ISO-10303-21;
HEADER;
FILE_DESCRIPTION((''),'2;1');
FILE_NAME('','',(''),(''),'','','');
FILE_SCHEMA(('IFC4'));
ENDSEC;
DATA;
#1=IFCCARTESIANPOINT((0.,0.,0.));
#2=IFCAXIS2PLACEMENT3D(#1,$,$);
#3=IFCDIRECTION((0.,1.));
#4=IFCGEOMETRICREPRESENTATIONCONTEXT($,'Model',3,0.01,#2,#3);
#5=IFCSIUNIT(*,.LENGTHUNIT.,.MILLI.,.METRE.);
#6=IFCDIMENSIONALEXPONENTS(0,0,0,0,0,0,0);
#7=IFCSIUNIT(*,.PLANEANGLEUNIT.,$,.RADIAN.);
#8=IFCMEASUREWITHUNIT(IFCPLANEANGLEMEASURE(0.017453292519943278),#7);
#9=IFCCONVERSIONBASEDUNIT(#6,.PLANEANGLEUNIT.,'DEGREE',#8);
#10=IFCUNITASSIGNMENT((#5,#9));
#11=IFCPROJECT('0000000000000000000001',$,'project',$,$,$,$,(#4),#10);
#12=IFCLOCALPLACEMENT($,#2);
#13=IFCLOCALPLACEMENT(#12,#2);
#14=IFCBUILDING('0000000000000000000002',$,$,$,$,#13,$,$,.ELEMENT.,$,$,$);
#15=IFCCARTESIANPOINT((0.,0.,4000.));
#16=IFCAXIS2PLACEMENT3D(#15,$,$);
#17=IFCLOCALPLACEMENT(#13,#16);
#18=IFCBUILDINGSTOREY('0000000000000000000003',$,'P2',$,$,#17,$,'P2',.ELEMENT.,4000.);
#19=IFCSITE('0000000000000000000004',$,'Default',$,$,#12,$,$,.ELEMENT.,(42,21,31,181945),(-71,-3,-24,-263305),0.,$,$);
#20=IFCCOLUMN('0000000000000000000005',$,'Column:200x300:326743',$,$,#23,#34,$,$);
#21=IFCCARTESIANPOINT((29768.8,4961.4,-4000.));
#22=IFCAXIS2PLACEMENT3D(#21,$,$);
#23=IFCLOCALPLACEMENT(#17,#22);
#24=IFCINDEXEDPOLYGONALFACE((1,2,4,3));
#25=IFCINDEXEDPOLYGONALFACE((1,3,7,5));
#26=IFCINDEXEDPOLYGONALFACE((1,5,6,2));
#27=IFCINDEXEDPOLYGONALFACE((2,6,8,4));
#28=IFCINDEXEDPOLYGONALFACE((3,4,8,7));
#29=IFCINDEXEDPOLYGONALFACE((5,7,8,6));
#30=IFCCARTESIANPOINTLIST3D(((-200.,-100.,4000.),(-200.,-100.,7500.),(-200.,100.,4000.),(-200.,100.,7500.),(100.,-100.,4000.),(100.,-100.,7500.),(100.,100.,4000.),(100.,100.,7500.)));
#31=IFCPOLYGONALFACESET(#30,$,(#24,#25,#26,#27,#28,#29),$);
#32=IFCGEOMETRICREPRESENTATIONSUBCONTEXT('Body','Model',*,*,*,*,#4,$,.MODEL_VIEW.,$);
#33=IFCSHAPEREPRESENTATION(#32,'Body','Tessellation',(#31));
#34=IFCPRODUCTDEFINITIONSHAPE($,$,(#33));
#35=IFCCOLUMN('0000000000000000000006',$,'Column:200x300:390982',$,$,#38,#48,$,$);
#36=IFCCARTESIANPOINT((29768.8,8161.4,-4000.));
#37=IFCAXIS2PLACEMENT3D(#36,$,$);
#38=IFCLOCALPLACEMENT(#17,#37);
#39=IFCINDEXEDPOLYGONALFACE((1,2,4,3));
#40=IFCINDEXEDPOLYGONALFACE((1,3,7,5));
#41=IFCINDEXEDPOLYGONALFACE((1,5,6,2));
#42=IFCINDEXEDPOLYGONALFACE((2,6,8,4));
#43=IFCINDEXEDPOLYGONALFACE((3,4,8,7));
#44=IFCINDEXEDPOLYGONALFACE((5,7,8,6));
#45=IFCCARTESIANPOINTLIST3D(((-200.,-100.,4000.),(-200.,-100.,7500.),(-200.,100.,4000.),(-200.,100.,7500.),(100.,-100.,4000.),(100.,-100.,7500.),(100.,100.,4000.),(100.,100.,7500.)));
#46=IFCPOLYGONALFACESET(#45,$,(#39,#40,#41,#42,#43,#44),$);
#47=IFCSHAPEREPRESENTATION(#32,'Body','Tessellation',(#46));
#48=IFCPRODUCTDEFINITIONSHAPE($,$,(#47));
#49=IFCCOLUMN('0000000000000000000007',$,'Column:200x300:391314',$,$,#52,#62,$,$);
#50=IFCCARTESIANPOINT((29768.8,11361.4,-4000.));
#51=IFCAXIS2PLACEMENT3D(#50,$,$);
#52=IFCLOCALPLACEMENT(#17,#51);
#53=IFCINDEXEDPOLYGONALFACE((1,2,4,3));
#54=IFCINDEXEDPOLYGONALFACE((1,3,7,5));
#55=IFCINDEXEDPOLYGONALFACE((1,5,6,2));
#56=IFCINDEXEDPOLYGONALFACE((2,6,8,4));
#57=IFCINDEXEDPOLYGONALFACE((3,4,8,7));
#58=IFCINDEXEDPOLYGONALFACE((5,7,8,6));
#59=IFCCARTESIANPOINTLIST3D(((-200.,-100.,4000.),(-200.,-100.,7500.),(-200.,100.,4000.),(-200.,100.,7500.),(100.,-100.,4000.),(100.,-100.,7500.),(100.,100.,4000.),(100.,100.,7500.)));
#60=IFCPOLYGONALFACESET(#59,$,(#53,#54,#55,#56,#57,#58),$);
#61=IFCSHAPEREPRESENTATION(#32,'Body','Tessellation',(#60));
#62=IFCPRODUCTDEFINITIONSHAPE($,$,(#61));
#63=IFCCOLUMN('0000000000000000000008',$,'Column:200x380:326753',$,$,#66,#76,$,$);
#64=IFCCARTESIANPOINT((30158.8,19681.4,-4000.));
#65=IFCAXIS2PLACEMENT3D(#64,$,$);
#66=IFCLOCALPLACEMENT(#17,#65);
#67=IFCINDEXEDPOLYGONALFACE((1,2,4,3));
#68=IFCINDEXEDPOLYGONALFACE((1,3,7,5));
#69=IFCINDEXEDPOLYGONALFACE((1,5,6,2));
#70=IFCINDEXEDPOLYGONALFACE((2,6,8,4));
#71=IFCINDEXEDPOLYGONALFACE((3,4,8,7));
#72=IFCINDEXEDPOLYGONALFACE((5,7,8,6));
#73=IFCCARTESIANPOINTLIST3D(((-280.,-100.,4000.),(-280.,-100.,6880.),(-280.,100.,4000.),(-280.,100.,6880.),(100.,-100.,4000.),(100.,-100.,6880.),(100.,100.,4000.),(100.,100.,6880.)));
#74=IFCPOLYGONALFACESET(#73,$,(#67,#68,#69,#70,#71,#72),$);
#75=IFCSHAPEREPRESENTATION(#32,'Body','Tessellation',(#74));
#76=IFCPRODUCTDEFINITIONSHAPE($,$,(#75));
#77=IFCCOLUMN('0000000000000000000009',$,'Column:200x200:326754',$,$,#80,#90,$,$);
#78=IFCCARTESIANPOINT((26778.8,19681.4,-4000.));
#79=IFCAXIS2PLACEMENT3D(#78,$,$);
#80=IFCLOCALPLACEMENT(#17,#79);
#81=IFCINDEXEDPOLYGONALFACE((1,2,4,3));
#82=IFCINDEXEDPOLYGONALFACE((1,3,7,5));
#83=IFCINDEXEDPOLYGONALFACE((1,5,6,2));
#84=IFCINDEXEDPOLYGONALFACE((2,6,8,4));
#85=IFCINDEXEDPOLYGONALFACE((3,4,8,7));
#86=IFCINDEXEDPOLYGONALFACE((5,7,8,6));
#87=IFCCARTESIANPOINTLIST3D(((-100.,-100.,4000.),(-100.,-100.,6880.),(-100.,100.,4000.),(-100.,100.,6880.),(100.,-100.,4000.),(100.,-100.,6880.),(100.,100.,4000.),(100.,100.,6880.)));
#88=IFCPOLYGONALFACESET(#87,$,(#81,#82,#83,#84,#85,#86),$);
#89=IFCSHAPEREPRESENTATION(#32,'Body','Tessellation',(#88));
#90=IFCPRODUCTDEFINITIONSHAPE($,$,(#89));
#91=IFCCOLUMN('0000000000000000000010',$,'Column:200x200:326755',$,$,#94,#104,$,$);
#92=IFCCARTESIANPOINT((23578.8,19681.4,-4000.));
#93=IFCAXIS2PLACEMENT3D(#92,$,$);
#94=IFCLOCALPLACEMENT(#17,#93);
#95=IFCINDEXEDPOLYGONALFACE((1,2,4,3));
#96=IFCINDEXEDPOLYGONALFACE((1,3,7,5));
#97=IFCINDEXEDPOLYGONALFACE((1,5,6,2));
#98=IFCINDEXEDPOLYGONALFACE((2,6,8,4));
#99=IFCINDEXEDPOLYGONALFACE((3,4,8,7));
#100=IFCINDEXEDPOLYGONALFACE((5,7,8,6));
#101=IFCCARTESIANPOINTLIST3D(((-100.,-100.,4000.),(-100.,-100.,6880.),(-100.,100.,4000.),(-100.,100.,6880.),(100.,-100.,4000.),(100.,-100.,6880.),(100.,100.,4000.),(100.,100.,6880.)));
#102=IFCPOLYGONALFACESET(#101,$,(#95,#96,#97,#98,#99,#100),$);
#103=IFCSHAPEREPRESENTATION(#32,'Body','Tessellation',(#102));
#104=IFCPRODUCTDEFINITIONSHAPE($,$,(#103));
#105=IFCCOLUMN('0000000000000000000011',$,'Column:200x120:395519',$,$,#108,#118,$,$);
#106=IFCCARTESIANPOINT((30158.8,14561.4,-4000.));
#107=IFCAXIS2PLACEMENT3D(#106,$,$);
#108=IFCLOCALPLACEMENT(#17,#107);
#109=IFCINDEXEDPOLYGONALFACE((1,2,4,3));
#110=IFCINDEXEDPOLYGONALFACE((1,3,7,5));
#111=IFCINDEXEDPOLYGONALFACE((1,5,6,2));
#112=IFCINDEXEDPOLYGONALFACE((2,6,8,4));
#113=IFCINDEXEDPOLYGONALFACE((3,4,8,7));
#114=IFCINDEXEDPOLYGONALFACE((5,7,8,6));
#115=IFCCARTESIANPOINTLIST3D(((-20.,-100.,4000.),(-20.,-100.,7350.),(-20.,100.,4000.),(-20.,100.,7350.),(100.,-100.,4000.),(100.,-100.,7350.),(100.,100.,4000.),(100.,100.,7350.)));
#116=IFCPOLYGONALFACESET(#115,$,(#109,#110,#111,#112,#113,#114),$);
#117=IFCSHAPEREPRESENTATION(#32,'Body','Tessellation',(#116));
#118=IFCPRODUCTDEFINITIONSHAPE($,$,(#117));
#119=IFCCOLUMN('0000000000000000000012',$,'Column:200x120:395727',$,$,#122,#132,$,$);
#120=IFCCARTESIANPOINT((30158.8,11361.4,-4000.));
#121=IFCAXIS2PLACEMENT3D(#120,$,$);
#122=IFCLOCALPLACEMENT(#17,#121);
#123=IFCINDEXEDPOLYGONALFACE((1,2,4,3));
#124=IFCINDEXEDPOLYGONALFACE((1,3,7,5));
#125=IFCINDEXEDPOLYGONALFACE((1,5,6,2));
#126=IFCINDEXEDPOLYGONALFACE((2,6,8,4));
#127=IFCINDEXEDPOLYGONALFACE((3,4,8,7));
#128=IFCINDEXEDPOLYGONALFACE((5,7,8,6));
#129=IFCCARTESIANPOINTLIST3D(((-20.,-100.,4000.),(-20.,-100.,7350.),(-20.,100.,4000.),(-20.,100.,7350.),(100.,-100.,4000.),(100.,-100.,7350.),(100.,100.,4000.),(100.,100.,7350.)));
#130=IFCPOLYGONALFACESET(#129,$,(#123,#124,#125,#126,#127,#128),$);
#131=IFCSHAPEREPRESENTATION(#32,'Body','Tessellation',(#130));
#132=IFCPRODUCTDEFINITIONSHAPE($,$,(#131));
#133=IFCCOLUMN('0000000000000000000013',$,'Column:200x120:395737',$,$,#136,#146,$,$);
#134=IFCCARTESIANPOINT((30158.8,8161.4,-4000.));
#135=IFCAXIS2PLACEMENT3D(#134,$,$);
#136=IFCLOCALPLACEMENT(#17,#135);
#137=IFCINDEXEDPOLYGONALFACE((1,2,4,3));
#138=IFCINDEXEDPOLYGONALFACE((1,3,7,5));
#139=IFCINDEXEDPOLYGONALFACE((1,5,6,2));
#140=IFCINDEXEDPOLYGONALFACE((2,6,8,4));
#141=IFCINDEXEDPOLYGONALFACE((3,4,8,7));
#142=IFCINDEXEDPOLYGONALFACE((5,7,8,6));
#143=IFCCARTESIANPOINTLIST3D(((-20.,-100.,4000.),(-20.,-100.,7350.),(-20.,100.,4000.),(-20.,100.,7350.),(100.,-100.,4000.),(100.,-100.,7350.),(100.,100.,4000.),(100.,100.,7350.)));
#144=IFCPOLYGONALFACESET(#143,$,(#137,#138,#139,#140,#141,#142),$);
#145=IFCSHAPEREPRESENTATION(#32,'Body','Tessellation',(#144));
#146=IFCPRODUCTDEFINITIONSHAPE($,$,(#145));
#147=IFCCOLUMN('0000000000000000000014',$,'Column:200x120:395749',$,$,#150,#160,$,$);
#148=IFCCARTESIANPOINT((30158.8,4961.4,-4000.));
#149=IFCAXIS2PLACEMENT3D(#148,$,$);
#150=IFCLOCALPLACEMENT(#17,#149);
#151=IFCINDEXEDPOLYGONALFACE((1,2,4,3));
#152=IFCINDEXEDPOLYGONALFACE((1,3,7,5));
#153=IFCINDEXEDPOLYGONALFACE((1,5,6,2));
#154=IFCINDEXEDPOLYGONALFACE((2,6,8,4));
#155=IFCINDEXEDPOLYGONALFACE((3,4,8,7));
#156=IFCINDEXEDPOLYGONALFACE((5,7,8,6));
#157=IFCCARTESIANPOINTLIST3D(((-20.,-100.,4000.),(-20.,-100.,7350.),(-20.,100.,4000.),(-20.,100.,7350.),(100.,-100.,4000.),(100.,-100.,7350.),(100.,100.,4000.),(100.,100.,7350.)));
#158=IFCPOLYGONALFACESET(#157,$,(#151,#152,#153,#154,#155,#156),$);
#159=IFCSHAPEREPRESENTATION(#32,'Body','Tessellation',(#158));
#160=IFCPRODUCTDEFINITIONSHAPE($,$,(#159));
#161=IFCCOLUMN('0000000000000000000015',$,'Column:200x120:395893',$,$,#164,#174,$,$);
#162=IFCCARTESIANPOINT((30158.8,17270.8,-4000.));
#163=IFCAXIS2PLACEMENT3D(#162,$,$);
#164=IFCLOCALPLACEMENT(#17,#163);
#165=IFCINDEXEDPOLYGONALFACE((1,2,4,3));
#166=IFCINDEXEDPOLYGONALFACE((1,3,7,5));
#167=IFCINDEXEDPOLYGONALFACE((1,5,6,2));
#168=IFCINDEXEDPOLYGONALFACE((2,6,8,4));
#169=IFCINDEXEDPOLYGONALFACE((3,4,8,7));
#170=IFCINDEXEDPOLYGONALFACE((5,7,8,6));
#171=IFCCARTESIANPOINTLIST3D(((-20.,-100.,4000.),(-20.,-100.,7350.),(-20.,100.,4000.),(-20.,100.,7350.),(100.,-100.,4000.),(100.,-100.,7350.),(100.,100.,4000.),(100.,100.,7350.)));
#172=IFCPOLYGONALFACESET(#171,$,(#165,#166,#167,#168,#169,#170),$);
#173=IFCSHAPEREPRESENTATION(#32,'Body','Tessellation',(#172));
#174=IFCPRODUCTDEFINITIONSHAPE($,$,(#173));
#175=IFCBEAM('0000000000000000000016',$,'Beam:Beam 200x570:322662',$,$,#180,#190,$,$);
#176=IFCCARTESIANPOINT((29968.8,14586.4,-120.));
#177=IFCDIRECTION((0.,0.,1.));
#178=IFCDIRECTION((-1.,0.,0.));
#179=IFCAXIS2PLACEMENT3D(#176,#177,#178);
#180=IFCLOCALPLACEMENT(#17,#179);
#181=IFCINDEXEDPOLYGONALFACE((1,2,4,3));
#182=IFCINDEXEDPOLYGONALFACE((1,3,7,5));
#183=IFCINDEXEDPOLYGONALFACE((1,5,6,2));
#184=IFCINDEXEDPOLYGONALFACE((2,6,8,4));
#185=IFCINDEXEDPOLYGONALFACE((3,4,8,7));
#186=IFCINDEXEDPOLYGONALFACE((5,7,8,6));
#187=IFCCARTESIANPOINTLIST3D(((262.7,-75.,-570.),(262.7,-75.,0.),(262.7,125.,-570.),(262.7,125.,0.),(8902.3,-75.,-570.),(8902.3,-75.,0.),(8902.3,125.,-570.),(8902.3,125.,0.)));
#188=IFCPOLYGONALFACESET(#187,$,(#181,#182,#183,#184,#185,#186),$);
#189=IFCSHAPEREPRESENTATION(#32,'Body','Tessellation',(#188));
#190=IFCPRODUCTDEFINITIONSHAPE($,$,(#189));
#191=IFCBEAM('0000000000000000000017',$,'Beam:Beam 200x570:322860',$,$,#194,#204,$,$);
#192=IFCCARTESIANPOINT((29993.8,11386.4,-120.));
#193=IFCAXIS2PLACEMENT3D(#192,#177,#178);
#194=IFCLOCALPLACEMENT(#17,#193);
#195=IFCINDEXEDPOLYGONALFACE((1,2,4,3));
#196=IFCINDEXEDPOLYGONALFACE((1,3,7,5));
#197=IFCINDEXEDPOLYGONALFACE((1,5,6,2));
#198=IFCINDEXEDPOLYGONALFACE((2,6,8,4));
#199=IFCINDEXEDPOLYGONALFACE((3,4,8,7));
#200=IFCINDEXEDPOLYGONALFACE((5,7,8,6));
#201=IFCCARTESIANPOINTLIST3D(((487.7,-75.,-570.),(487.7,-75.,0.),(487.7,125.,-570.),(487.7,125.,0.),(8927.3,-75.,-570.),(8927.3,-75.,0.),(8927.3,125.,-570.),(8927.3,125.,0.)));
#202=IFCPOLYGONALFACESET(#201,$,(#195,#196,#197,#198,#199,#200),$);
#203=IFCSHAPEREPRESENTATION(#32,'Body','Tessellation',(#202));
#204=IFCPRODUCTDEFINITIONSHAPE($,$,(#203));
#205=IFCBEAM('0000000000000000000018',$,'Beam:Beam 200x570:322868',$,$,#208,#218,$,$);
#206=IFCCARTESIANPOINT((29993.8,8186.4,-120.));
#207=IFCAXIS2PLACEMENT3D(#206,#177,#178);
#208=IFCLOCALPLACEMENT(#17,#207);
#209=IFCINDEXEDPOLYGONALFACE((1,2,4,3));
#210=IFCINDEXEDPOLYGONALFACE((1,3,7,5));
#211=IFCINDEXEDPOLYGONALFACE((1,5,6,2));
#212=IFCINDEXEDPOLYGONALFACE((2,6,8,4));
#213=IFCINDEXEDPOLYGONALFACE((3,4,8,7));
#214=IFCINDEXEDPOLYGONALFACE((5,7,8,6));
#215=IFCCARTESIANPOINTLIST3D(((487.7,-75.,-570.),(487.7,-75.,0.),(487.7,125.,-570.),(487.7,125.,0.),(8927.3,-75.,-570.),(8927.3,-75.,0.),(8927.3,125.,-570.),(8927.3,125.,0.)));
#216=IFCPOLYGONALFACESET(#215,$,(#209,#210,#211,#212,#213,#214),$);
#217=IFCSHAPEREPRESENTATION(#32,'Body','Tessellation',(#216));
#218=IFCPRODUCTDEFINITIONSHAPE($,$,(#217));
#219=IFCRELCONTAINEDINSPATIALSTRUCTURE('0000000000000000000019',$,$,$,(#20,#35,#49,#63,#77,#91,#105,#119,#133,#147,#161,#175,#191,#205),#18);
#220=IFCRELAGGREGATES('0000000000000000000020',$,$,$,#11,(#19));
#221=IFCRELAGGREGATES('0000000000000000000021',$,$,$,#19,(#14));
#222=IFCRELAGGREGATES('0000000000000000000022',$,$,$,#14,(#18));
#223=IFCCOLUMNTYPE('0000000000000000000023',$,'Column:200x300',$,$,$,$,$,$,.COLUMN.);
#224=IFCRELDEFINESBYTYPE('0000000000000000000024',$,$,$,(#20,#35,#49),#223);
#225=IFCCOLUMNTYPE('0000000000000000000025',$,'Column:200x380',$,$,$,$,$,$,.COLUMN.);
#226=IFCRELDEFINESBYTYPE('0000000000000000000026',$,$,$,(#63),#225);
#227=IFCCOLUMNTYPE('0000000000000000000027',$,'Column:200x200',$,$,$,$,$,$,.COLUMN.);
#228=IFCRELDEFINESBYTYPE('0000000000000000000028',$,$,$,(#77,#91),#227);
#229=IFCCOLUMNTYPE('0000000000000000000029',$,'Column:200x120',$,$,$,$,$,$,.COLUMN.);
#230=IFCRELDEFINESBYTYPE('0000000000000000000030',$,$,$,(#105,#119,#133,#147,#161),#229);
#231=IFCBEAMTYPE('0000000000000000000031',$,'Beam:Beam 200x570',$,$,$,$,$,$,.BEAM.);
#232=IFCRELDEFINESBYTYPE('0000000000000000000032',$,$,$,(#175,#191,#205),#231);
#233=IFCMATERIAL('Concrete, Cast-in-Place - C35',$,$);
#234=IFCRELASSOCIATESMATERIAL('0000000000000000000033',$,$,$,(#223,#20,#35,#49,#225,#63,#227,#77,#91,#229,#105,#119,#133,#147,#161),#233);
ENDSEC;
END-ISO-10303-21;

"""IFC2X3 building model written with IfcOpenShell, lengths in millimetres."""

from ifc_helpers import new_model, entity, si_unit, converted_unit, direction, frame, frame_2d, origin, origin_2d_with_axis, place, context, subcontext, project, spatial, rectangle, extrude, source, transform, mapped, material, type_object, type_shapes, element, save


model = new_model("IFC2X3")

# Units and contexts
model_context = context("Model", 3, precision=0.01, world=origin(), true_north=direction((0.0, 1.0)))
body_context = subcontext(model_context, "Body", "Model", "MODEL_VIEW")
ifc_project = project(units=[si_unit("LENGTHUNIT", "METRE", prefix="MILLI"), converted_unit("PLANEANGLEUNIT", "DEGREE", entity("IfcPlaneAngleMeasure", 0.017453292519943278), si_unit("PLANEANGLEUNIT", "RADIAN"), dimensions=[0, 0, 0, 0, 0, 0, 0])], contexts=[model_context])

# Site, building, storey
site_placement = place(None, origin())
site = spatial("IfcSite", under=ifc_project, at=site_placement, Name="Default", CompositionType="ELEMENT", RefLatitude=(42, 21, 31, 181945), RefLongitude=(-71, -3, -24, -263305), RefElevation=0.0)
building_placement = place(site_placement, origin())
building = spatial("IfcBuilding", under=site, at=building_placement, CompositionType="ELEMENT")
storey_placement = place(building_placement, frame((0.0, 0.0, 4000.0)))
storey = spatial("IfcBuildingStorey", under=building, at=storey_placement, Name="P2", LongName="P2", CompositionType="ELEMENT", Elevation=4000.0)

# Columns
ifc_material = material(Name="Concrete, Cast-in-Place - C35")
column_type_1 = type_object("IfcColumnType", Name="Column:200x300", PredefinedType="COLUMN", material=ifc_material)
shared_shape_1 = source(origin(), body_context, "Body", "SweptSolid", [
    extrude(rectangle(XDim=300.0, YDim=200.0, at=origin_2d_with_axis()), frame((-50.0, 0.0, 4000.0), z_axis=(0.0, 0.0, 1.0), x_axis=(-1.0, 0.0, 0.0)), (0.0, 0.0, 1.0), 3500.0),
])
type_shapes(column_type_1, [shared_shape_1])
for number, where, name in (
    (1, (29768.8, 4961.4, -4000.0), "Column:200x300:326743"),
    (2, (29768.8, 8161.4, -4000.0), "Column:200x300:390982"),
    (3, (29768.8, 11361.4, -4000.0), "Column:200x300:391314"),
):
    element("IfcColumn", number, at=place(storey_placement, frame(where)), inside=storey, type_object=column_type_1, material=ifc_material, Name=name, context=body_context, shape_type="MappedRepresentation", body=[
        mapped(shared_shape_1, transform((0.0, 0.0, 0.0), scale=1.0)),
    ])
column_type_2 = type_object("IfcColumnType", Name="Column:200x380", PredefinedType="COLUMN", material=ifc_material)
shared_shape_2 = source(origin(), body_context, "Body", "SweptSolid", [
    extrude(rectangle(XDim=380.0, YDim=200.0, at=origin_2d_with_axis()), frame((-90.0, 0.0, 4000.0), z_axis=(0.0, 0.0, 1.0), x_axis=(-1.0, 0.0, 0.0)), (0.0, 0.0, 1.0), 2880.0),
])
type_shapes(column_type_2, [shared_shape_2])
column_placement = place(storey_placement, frame((30158.8, 19681.4, -4000.0)))
element("IfcColumn", 4, at=column_placement, inside=storey, type_object=column_type_2, material=ifc_material, Name="Column:200x380:326753", context=body_context, shape_type="MappedRepresentation", body=[
    mapped(shared_shape_2, transform((0.0, 0.0, 0.0), scale=1.0)),
])
column_type_3 = type_object("IfcColumnType", Name="Column:200x200", PredefinedType="COLUMN", material=ifc_material)
shared_shape_3 = source(origin(), body_context, "Body", "SweptSolid", [
    extrude(rectangle(XDim=200.0, YDim=200.0, at=frame_2d((0.0, 0.0), x_axis=(1.0, 0.0))), frame((0.0, 0.0, 4000.0), z_axis=(0.0, 0.0, 1.0), x_axis=(-1.0, 0.0, 0.0)), (0.0, 0.0, 1.0), 2880.0),
])
type_shapes(column_type_3, [shared_shape_3])
for number, where, name in (
    (5, (26778.8, 19681.4, -4000.0), "Column:200x200:326754"),
    (6, (23578.8, 19681.4, -4000.0), "Column:200x200:326755"),
):
    element("IfcColumn", number, at=place(storey_placement, frame(where)), inside=storey, type_object=column_type_3, material=ifc_material, Name=name, context=body_context, shape_type="MappedRepresentation", body=[
        mapped(shared_shape_3, transform((0.0, 0.0, 0.0), scale=1.0)),
    ])
column_type_4 = type_object("IfcColumnType", Name="Column:200x120", PredefinedType="COLUMN", material=ifc_material)
shared_shape_4 = source(origin(), body_context, "Body", "SweptSolid", [
    extrude(rectangle(XDim=120.0, YDim=200.0, at=origin_2d_with_axis()), frame((40.0, 0.0, 4000.0), z_axis=(0.0, 0.0, 1.0), x_axis=(-1.0, 0.0, 0.0)), (0.0, 0.0, 1.0), 3350.0),
])
type_shapes(column_type_4, [shared_shape_4])
for number, where, name in (
    (7, (30158.8, 14561.4, -4000.0), "Column:200x120:395519"),
    (8, (30158.8, 11361.4, -4000.0), "Column:200x120:395727"),
    (9, (30158.8, 8161.4, -4000.0), "Column:200x120:395737"),
    (10, (30158.8, 4961.4, -4000.0), "Column:200x120:395749"),
    (11, (30158.8, 17270.8, -4000.0), "Column:200x120:395893"),
):
    element("IfcColumn", number, at=place(storey_placement, frame(where)), inside=storey, type_object=column_type_4, material=ifc_material, Name=name, context=body_context, shape_type="MappedRepresentation", body=[
        mapped(shared_shape_4, transform((0.0, 0.0, 0.0), scale=1.0)),
    ])

# Beams
beam_type_1 = type_object("IfcBeamType", Name="Beam:Beam 200x570", PredefinedType="BEAM")
beam_1_placement = place(storey_placement, frame((29968.8, 14586.4, -120.0), z_axis=(0.0, 0.0, 1.0), x_axis=(-1.0, 0.0, 0.0)))
element("IfcBeam", 12, at=beam_1_placement, inside=storey, type_object=beam_type_1, Name="Beam:Beam 200x570:322662", context=body_context, shape_type="SweptSolid", body=[
    extrude(rectangle(XDim=570.0, YDim=200.0, at=frame_2d((0.0, 0.0), x_axis=(1.0, 0.0))), frame((262.7, 25.0, -285.0), z_axis=(1.0, 0.0, 0.0), x_axis=(0.0, 0.0, -1.0)), (0.0, 0.0, 1.0), 8639.6),
])
beam_2_placement = place(storey_placement, frame((29993.8, 11386.4, -120.0), z_axis=(0.0, 0.0, 1.0), x_axis=(-1.0, 0.0, 0.0)))
element("IfcBeam", 13, at=beam_2_placement, inside=storey, type_object=beam_type_1, Name="Beam:Beam 200x570:322860", context=body_context, shape_type="SweptSolid", body=[
    extrude(rectangle(XDim=570.0, YDim=200.0, at=frame_2d((0.0, 0.0), x_axis=(1.0, 0.0))), frame((487.7, 25.0, -285.0), z_axis=(1.0, 0.0, 0.0), x_axis=(0.0, 0.0, -1.0)), (0.0, 0.0, 1.0), 8439.6),
])
beam_3_placement = place(storey_placement, frame((29993.8, 8186.4, -120.0), z_axis=(0.0, 0.0, 1.0), x_axis=(-1.0, 0.0, 0.0)))
element("IfcBeam", 14, at=beam_3_placement, inside=storey, type_object=beam_type_1, Name="Beam:Beam 200x570:322868", context=body_context, shape_type="SweptSolid", body=[
    extrude(rectangle(XDim=570.0, YDim=200.0, at=frame_2d((0.0, 0.0), x_axis=(1.0, 0.0))), frame((487.7, 25.0, -285.0), z_axis=(1.0, 0.0, 0.0), x_axis=(0.0, 0.0, -1.0)), (0.0, 0.0, 1.0), 8439.6),
])

save(model, "model.ifc")
